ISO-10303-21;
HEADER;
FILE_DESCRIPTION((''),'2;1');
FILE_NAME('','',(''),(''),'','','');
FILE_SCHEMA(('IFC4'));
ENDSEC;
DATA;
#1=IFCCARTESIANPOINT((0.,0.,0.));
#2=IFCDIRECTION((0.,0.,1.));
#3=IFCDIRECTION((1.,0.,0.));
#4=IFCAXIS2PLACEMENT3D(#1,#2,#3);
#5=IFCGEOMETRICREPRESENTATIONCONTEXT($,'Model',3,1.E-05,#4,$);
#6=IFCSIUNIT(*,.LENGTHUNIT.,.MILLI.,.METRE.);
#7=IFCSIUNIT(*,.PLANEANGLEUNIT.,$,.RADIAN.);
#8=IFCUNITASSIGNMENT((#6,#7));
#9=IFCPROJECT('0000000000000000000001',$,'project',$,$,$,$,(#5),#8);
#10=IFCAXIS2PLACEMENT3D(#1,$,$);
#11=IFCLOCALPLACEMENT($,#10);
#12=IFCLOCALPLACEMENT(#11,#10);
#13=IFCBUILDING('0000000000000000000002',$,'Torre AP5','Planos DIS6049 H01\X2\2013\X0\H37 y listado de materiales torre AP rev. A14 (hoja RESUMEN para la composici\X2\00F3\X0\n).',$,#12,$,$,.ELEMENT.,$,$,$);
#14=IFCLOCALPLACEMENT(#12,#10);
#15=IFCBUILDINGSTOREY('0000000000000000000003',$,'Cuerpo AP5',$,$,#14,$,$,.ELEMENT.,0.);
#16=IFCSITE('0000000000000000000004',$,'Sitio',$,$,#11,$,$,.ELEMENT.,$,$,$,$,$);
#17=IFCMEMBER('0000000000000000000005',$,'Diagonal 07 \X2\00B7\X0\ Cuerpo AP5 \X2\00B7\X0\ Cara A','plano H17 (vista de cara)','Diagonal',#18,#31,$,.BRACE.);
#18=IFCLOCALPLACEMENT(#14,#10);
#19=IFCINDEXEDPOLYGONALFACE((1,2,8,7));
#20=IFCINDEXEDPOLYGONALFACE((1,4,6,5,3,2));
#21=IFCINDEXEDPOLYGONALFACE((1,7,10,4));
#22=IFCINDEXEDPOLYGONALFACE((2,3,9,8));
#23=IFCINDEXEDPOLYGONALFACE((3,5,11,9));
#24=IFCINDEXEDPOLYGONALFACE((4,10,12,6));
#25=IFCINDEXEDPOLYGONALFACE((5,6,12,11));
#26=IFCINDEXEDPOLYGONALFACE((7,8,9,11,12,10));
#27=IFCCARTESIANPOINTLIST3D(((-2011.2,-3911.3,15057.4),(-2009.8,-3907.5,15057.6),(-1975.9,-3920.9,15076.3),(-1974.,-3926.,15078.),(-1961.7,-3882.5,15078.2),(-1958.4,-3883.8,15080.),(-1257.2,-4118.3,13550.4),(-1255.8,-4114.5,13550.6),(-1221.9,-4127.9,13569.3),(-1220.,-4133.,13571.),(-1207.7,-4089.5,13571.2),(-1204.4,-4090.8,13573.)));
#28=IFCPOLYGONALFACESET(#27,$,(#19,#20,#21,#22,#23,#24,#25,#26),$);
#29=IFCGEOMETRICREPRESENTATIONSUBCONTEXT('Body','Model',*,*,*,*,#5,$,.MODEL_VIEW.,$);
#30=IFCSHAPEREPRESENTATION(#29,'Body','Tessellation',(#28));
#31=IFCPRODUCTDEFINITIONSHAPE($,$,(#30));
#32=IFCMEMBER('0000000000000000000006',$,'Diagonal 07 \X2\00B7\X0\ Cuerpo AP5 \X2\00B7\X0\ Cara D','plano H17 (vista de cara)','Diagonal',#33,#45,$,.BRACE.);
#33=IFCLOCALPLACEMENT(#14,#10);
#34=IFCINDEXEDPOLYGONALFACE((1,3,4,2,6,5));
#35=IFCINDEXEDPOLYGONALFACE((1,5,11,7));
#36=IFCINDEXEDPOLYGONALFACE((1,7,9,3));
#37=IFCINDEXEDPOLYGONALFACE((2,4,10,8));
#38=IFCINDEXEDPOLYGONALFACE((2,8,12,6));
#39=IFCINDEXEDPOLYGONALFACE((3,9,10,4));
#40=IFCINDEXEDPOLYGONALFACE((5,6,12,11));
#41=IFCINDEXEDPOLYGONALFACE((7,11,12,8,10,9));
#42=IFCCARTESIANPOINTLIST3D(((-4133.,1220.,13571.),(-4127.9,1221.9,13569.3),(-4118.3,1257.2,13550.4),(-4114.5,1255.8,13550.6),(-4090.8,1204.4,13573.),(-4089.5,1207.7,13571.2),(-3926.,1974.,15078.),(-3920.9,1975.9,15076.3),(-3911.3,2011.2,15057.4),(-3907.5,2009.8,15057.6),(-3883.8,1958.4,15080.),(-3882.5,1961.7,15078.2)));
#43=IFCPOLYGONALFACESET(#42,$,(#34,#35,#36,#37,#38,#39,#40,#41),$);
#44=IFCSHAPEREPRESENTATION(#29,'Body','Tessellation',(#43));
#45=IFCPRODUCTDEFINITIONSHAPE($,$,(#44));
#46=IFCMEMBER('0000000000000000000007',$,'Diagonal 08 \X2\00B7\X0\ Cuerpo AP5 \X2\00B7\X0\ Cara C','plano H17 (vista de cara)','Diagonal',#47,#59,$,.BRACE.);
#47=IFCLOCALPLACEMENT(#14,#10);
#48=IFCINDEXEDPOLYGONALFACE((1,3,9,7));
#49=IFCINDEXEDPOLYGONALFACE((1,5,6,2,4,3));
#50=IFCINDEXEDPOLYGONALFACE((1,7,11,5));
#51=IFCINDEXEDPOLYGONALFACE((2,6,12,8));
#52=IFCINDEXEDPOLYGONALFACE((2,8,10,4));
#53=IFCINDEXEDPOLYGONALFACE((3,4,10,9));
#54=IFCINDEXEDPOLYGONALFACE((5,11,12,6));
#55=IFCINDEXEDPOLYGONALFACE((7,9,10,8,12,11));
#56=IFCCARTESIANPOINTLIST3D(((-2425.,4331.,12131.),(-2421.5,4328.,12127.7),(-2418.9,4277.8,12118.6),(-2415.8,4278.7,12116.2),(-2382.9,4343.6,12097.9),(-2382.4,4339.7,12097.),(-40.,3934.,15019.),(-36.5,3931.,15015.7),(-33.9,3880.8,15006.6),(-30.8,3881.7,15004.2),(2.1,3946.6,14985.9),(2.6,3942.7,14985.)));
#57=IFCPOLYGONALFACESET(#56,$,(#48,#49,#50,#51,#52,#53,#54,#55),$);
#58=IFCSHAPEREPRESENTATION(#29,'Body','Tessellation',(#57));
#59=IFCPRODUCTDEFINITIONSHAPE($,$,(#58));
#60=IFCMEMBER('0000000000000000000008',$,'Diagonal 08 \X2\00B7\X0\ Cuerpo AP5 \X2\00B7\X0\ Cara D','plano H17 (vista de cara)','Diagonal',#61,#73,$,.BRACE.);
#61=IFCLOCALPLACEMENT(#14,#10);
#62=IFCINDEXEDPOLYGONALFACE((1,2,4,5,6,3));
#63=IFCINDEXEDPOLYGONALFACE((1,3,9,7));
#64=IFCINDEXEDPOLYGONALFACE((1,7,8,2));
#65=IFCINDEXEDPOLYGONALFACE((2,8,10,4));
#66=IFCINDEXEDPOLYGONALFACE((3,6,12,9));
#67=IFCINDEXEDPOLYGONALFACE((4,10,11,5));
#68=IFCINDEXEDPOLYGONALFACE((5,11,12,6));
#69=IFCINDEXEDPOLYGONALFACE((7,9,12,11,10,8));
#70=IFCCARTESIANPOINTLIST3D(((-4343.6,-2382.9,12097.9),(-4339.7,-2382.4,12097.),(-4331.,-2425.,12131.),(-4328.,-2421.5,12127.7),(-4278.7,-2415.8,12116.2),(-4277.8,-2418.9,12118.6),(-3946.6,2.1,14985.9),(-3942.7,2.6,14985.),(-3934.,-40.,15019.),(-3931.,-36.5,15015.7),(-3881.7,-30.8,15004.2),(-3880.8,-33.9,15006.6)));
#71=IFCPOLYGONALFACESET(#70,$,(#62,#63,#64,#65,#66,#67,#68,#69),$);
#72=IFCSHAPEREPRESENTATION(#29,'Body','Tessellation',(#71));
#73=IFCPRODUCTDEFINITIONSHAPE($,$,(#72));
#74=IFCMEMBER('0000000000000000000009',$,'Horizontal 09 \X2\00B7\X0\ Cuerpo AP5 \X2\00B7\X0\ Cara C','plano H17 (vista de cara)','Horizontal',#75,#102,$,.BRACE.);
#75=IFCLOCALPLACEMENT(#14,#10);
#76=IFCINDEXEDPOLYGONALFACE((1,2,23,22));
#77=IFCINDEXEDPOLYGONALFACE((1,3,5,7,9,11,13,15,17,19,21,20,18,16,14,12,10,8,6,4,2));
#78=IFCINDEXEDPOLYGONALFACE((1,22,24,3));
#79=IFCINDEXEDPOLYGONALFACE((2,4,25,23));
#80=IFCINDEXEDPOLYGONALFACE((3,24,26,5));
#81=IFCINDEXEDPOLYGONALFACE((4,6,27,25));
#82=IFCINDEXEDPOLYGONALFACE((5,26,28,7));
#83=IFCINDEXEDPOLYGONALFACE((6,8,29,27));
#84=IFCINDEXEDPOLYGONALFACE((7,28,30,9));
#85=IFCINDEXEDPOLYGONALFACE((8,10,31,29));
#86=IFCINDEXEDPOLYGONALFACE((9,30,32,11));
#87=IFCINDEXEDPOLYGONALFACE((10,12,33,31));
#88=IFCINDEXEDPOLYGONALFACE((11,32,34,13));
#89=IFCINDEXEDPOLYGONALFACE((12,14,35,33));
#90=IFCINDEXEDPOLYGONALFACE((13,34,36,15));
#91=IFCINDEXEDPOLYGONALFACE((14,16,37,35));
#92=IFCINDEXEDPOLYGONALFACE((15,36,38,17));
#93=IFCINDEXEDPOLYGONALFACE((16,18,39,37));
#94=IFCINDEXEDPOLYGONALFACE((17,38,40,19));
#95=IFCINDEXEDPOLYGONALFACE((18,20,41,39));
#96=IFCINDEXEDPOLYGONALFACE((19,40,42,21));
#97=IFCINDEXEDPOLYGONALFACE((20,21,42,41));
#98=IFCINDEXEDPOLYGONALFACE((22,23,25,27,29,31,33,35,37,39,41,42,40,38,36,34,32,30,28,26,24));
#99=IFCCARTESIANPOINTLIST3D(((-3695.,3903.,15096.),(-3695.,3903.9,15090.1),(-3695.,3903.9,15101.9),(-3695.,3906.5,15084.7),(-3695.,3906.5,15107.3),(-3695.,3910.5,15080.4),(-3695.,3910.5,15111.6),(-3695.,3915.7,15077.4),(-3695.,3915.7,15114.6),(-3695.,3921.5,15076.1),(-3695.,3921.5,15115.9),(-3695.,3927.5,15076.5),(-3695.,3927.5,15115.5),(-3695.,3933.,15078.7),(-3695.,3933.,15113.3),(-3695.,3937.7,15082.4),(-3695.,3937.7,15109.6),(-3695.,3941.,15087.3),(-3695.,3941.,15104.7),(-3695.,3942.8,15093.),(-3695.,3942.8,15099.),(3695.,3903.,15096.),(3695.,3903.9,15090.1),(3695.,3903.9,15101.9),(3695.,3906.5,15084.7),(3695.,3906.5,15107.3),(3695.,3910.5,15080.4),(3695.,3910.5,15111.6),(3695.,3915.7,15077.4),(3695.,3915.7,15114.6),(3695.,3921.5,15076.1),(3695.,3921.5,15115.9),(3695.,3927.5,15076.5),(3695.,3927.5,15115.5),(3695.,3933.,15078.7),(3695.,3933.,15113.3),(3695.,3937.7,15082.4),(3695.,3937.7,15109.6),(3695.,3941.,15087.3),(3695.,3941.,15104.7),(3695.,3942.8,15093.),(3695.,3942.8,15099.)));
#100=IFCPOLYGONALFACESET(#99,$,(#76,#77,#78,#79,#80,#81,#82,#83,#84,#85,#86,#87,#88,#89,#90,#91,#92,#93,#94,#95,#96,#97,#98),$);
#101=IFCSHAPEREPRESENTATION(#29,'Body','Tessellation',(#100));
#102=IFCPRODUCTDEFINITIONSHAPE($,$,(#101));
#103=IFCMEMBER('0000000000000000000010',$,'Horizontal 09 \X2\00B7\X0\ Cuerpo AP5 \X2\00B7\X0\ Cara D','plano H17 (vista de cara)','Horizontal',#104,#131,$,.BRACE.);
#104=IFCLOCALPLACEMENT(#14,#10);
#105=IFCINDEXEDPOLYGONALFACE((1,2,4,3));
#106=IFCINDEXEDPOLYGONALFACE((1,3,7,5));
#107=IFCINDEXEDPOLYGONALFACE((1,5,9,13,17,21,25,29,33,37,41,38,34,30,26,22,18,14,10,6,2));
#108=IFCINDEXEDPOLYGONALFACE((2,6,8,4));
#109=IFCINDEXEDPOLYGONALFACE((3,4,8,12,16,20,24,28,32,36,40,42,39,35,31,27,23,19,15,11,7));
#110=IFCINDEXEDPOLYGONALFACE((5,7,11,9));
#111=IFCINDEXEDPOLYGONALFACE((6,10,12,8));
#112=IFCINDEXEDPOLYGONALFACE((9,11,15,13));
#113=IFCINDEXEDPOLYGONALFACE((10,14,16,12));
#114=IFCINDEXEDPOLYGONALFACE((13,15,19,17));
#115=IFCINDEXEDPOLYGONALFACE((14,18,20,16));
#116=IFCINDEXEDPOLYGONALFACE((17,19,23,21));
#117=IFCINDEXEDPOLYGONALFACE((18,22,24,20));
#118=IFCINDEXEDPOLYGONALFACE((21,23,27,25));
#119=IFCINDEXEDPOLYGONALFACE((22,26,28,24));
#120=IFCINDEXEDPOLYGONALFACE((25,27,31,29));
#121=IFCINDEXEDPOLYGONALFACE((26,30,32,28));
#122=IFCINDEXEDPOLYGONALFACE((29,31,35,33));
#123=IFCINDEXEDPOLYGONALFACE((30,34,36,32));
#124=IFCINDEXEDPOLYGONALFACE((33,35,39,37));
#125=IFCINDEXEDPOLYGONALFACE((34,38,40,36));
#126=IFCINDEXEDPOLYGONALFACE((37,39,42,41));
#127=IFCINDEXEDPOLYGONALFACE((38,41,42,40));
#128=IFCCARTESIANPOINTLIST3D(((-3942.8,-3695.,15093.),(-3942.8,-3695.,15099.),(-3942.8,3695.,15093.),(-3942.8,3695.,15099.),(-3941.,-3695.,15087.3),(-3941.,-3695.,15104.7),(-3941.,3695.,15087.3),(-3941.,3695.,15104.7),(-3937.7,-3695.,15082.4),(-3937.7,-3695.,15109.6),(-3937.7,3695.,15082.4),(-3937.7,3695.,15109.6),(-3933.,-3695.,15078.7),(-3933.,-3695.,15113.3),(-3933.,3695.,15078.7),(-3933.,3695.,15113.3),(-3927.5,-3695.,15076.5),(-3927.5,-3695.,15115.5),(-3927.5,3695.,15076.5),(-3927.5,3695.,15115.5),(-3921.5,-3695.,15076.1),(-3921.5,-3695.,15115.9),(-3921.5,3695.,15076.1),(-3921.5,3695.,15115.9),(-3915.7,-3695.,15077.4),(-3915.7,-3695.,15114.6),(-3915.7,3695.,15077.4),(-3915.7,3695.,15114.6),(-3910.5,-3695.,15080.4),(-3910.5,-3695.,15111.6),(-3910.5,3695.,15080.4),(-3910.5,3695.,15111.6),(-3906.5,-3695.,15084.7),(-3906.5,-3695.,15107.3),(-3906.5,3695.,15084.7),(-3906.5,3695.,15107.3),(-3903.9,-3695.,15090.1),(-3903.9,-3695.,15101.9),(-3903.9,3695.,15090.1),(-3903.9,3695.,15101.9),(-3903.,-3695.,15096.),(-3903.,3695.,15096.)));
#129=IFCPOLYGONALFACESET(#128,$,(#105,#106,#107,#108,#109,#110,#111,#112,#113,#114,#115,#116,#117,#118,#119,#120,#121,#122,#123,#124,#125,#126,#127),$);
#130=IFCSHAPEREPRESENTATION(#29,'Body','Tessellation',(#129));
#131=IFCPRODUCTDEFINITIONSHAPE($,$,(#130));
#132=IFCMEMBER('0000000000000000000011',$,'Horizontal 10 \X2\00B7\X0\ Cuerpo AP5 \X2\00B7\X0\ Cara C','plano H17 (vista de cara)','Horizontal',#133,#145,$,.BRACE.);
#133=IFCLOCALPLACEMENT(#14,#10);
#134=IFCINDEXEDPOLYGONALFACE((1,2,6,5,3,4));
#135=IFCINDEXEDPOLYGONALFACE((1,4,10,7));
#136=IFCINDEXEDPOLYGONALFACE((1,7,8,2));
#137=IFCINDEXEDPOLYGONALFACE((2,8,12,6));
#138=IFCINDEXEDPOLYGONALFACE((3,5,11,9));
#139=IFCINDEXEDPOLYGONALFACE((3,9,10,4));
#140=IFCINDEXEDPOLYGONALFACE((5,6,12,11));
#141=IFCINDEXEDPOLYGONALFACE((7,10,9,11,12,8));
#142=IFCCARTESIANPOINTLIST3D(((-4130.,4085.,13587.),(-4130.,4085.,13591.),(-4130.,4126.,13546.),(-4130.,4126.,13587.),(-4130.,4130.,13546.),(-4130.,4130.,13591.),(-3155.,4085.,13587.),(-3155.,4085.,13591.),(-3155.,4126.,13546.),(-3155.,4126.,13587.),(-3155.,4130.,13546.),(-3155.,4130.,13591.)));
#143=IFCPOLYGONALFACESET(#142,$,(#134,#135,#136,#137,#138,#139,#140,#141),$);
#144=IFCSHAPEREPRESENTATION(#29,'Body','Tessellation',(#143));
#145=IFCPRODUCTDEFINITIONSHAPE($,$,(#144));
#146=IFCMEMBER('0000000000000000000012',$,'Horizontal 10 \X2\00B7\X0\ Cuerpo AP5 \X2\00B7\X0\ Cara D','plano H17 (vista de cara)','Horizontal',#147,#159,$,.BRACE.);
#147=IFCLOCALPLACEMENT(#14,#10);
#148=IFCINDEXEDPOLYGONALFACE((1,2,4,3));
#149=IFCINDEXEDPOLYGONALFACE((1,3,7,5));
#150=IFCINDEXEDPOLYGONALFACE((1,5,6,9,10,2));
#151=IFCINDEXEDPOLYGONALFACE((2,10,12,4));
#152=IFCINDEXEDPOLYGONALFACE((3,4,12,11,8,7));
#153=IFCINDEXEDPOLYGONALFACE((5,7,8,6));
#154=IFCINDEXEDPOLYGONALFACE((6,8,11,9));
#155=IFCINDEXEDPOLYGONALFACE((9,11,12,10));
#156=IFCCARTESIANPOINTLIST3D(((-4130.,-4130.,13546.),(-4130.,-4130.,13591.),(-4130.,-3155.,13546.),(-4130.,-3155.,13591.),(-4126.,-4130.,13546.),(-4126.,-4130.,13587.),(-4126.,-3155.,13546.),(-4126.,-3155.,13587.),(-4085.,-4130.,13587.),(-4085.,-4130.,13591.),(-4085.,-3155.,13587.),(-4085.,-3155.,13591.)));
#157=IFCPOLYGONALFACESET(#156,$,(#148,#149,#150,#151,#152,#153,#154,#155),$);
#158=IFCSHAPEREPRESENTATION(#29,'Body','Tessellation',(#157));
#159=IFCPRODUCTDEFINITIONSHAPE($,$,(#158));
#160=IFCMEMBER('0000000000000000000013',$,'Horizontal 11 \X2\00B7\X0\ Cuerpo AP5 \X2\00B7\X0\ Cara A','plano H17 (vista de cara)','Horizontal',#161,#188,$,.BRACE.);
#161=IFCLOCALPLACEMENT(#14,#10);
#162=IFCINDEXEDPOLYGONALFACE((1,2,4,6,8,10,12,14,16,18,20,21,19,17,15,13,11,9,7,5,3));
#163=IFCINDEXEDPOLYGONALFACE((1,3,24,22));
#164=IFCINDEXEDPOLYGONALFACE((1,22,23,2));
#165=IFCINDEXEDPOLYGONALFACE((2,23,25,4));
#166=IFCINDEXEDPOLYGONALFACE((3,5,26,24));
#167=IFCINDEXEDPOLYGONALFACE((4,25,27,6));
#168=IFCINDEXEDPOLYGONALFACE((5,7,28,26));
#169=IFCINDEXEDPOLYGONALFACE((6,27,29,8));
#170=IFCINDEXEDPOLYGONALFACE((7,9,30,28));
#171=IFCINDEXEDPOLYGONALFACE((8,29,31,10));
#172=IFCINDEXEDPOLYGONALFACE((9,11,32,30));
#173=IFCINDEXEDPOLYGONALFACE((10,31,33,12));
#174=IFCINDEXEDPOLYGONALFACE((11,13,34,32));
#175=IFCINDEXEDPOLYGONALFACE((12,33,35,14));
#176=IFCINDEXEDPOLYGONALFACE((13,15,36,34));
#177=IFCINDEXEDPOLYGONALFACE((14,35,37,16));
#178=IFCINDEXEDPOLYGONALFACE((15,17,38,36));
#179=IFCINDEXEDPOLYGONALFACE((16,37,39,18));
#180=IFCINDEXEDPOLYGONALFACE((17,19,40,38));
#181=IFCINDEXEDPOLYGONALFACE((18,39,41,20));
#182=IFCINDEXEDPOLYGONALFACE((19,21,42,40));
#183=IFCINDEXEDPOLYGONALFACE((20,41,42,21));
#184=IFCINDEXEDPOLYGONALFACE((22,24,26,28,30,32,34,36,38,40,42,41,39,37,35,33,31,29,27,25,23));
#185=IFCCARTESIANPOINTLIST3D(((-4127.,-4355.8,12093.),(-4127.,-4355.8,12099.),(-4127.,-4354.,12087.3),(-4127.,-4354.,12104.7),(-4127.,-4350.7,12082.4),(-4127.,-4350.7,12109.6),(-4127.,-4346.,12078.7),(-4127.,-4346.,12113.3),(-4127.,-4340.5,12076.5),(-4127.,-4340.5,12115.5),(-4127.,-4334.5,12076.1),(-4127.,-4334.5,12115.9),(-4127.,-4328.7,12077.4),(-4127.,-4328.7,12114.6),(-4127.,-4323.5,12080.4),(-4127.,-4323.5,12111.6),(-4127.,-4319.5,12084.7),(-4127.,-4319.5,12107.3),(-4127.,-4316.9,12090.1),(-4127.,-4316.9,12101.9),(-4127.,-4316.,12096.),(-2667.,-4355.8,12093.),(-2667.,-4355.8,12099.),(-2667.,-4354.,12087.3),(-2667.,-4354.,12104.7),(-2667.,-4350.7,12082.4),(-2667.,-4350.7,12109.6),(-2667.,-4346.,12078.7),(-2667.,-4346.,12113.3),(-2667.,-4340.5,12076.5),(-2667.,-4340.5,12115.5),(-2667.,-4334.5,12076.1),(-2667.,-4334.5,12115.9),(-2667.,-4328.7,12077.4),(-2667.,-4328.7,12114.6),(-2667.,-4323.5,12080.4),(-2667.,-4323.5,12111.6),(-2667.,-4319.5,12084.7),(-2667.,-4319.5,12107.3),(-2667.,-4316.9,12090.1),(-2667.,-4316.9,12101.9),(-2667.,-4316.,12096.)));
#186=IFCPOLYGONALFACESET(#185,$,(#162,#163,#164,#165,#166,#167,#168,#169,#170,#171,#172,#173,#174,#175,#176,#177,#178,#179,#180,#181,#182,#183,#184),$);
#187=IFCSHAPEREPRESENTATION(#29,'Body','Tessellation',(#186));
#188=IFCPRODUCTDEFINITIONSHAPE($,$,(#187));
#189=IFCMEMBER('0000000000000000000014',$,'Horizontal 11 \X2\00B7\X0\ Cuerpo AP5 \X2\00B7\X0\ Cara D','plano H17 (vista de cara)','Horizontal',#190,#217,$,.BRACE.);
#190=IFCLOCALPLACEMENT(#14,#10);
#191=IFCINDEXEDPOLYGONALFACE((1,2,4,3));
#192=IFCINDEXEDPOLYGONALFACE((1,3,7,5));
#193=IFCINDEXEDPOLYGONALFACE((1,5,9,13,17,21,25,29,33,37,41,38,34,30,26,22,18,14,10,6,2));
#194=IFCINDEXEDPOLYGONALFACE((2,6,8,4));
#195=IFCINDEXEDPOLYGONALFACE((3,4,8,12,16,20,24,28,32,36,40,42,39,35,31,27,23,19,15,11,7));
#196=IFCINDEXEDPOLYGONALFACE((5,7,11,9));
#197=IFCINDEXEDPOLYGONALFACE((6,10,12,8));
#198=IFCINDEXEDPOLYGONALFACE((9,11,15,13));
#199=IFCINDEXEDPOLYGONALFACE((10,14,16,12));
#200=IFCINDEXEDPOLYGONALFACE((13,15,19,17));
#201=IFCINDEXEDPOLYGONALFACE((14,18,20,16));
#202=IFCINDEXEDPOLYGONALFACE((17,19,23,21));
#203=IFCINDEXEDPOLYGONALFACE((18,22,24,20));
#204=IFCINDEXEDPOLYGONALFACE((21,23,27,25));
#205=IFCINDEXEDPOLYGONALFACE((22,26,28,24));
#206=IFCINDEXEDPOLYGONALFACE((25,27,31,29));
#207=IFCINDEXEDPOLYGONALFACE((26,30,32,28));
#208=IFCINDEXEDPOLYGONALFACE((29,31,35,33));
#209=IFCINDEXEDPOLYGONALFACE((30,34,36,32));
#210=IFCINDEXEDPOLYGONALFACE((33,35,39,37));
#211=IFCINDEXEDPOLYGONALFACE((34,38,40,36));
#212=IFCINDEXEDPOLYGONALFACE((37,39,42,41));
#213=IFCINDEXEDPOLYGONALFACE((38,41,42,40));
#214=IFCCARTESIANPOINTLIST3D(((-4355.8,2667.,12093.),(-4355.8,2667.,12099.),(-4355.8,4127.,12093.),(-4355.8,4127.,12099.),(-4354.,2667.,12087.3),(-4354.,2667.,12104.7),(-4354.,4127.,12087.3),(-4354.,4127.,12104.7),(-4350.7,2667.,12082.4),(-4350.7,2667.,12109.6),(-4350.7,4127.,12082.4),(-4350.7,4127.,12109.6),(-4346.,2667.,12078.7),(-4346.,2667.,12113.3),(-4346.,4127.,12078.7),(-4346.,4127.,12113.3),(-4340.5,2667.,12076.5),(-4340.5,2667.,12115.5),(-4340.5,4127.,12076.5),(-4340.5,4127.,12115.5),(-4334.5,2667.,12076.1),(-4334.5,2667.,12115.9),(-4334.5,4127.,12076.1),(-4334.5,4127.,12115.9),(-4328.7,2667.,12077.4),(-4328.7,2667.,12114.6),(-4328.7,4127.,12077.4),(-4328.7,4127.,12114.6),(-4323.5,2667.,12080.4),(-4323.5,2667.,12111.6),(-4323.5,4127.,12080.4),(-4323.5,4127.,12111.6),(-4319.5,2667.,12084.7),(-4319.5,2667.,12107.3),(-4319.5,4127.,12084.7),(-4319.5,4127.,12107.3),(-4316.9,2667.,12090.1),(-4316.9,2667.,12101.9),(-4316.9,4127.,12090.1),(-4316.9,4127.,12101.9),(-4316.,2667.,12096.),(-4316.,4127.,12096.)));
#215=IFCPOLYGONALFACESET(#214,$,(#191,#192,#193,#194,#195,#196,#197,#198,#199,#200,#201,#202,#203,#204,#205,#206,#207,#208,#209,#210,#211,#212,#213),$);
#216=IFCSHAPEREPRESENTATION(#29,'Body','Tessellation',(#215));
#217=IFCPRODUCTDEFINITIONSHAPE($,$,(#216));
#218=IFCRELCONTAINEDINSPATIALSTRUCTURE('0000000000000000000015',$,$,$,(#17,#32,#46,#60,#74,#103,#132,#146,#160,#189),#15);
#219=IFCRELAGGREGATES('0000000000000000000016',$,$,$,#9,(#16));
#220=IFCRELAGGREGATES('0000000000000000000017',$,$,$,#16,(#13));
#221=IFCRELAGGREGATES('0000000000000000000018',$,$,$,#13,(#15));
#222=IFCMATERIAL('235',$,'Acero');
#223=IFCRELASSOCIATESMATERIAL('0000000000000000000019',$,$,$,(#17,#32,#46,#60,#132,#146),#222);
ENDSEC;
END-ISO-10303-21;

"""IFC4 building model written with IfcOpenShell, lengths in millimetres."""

from ifc_helpers import new_model, si_unit, frame, frame_2d, origin, origin_with_axes, place, context, subcontext, project, spatial, circle, l_section, extrude, material, element, save


model = new_model("IFC4")

# Units and contexts
model_context = context("Model", 3, precision=1e-05, world=origin_with_axes())
body_context = subcontext(model_context, "Body", "Model", "MODEL_VIEW")
ifc_project = project(units=[si_unit("LENGTHUNIT", "METRE", prefix="MILLI"), si_unit("PLANEANGLEUNIT", "RADIAN")], contexts=[model_context])

# Site, building, storey
site_placement = place(None, origin())
site = spatial("IfcSite", under=ifc_project, at=site_placement, Name="Sitio", CompositionType="ELEMENT")
building_placement = place(site_placement, origin())
building = spatial("IfcBuilding", under=site, at=building_placement, Name="Torre AP5", Description="Planos DIS6049 H01–H37 y listado de materiales torre AP rev. A14 (hoja RESUMEN para la composición).", CompositionType="ELEMENT")
storey_placement = place(building_placement, origin())
storey = spatial("IfcBuildingStorey", under=building, at=storey_placement, Name="Cuerpo AP5", CompositionType="ELEMENT", Elevation=0.0)

# Members
ifc_material_1 = material(Name="235", Category="Acero")
for number, where, z_axis, x_axis, name in (
    (1, (-1220.0, -4133.0, 13571.0), (-0.444113, 0.121925, 0.887636), (0.346552, 0.936966, 0.04469), "Diagonal 07 · Cuerpo AP5 · Cara A"),
    (2, (-4133.0, 1220.0, 13571.0), (0.121925, 0.444113, 0.887636), (0.936966, -0.346552, 0.04469), "Diagonal 07 · Cuerpo AP5 · Cara D"),
):
    element("IfcMember", number, at=place(storey_placement, frame(where, z_axis=z_axis, x_axis=x_axis)), inside=storey, material=ifc_material_1, Name=name, Description="plano H17 (vista de cara)", ObjectType="Diagonal", PredefinedType="BRACE", context=body_context, shape_type="SweptSolid", body=[
        extrude(l_section(Depth=45.0, Width=45.0, Thickness=4.0, at=frame_2d((22.5, 22.5))), None, (0.0, 0.0, 1.0), 1697.8),
    ])
for number, where, z_axis, x_axis, name in (
    (3, (-2425.0, 4331.0, 12131.0), (0.633217, -0.105403, 0.766763), (0.111785, -0.967841, -0.22536), "Diagonal 08 · Cuerpo AP5 · Cara C"),
    (4, (-4331.0, -2425.0, 12131.0), (0.105403, 0.633217, 0.766763), (0.967841, 0.111785, -0.22536), "Diagonal 08 · Cuerpo AP5 · Cara D"),
):
    element("IfcMember", number, at=place(storey_placement, frame(where, z_axis=z_axis, x_axis=x_axis)), inside=storey, material=ifc_material_1, Name=name, Description="plano H17 (vista de cara)", ObjectType="Diagonal", PredefinedType="BRACE", context=body_context, shape_type="SweptSolid", body=[
        extrude(l_section(Depth=55.0, Width=55.0, Thickness=4.0, at=frame_2d((27.5, 27.5))), None, (0.0, 0.0, 1.0), 3766.5),
    ])
for number, where, z_axis, x_axis, name in (
    (5, (-3695.0, 3923.0, 15096.0), (1.0, 0.0, 0.0), (0.0, -1.0, 0.0), "Horizontal 09 · Cuerpo AP5 · Cara C"),
    (6, (-3923.0, -3695.0, 15096.0), (0.0, 1.0, 0.0), (1.0, 0.0, 0.0), "Horizontal 09 · Cuerpo AP5 · Cara D"),
):
    element("IfcMember", number, at=place(storey_placement, frame(where, z_axis=z_axis, x_axis=x_axis)), inside=storey, Name=name, Description="plano H17 (vista de cara)", ObjectType="Horizontal", PredefinedType="BRACE", context=body_context, shape_type="SweptSolid", body=[
        extrude(circle(Radius=20.0), None, (0.0, 0.0, 1.0), 7390.0),
    ])
for number, where, z_axis, x_axis, name in (
    (7, (-4130.0, 4130.0, 13591.0), (1.0, 0.0, 0.0), (0.0, -1.0, 0.0), "Horizontal 10 · Cuerpo AP5 · Cara C"),
    (8, (-4130.0, -4130.0, 13591.0), (0.0, 1.0, 0.0), (1.0, 0.0, 0.0), "Horizontal 10 · Cuerpo AP5 · Cara D"),
):
    element("IfcMember", number, at=place(storey_placement, frame(where, z_axis=z_axis, x_axis=x_axis)), inside=storey, material=ifc_material_1, Name=name, Description="plano H17 (vista de cara)", ObjectType="Horizontal", PredefinedType="BRACE", context=body_context, shape_type="SweptSolid", body=[
        extrude(l_section(Depth=45.0, Width=45.0, Thickness=4.0, at=frame_2d((22.5, 22.5))), None, (0.0, 0.0, 1.0), 975.0),
    ])
for number, where, z_axis, x_axis, name in (
    (9, (-2667.0, -4336.0, 12096.0), (-1.0, 0.0, 0.0), (0.0, 1.0, 0.0), "Horizontal 11 · Cuerpo AP5 · Cara A"),
    (10, (-4336.0, 2667.0, 12096.0), (0.0, 1.0, 0.0), (1.0, 0.0, 0.0), "Horizontal 11 · Cuerpo AP5 · Cara D"),
):
    element("IfcMember", number, at=place(storey_placement, frame(where, z_axis=z_axis, x_axis=x_axis)), inside=storey, Name=name, Description="plano H17 (vista de cara)", ObjectType="Horizontal", PredefinedType="BRACE", context=body_context, shape_type="SweptSolid", body=[
        extrude(circle(Radius=20.0), None, (0.0, 0.0, 1.0), 1460.0),
    ])

save(model, "model.ifc")
